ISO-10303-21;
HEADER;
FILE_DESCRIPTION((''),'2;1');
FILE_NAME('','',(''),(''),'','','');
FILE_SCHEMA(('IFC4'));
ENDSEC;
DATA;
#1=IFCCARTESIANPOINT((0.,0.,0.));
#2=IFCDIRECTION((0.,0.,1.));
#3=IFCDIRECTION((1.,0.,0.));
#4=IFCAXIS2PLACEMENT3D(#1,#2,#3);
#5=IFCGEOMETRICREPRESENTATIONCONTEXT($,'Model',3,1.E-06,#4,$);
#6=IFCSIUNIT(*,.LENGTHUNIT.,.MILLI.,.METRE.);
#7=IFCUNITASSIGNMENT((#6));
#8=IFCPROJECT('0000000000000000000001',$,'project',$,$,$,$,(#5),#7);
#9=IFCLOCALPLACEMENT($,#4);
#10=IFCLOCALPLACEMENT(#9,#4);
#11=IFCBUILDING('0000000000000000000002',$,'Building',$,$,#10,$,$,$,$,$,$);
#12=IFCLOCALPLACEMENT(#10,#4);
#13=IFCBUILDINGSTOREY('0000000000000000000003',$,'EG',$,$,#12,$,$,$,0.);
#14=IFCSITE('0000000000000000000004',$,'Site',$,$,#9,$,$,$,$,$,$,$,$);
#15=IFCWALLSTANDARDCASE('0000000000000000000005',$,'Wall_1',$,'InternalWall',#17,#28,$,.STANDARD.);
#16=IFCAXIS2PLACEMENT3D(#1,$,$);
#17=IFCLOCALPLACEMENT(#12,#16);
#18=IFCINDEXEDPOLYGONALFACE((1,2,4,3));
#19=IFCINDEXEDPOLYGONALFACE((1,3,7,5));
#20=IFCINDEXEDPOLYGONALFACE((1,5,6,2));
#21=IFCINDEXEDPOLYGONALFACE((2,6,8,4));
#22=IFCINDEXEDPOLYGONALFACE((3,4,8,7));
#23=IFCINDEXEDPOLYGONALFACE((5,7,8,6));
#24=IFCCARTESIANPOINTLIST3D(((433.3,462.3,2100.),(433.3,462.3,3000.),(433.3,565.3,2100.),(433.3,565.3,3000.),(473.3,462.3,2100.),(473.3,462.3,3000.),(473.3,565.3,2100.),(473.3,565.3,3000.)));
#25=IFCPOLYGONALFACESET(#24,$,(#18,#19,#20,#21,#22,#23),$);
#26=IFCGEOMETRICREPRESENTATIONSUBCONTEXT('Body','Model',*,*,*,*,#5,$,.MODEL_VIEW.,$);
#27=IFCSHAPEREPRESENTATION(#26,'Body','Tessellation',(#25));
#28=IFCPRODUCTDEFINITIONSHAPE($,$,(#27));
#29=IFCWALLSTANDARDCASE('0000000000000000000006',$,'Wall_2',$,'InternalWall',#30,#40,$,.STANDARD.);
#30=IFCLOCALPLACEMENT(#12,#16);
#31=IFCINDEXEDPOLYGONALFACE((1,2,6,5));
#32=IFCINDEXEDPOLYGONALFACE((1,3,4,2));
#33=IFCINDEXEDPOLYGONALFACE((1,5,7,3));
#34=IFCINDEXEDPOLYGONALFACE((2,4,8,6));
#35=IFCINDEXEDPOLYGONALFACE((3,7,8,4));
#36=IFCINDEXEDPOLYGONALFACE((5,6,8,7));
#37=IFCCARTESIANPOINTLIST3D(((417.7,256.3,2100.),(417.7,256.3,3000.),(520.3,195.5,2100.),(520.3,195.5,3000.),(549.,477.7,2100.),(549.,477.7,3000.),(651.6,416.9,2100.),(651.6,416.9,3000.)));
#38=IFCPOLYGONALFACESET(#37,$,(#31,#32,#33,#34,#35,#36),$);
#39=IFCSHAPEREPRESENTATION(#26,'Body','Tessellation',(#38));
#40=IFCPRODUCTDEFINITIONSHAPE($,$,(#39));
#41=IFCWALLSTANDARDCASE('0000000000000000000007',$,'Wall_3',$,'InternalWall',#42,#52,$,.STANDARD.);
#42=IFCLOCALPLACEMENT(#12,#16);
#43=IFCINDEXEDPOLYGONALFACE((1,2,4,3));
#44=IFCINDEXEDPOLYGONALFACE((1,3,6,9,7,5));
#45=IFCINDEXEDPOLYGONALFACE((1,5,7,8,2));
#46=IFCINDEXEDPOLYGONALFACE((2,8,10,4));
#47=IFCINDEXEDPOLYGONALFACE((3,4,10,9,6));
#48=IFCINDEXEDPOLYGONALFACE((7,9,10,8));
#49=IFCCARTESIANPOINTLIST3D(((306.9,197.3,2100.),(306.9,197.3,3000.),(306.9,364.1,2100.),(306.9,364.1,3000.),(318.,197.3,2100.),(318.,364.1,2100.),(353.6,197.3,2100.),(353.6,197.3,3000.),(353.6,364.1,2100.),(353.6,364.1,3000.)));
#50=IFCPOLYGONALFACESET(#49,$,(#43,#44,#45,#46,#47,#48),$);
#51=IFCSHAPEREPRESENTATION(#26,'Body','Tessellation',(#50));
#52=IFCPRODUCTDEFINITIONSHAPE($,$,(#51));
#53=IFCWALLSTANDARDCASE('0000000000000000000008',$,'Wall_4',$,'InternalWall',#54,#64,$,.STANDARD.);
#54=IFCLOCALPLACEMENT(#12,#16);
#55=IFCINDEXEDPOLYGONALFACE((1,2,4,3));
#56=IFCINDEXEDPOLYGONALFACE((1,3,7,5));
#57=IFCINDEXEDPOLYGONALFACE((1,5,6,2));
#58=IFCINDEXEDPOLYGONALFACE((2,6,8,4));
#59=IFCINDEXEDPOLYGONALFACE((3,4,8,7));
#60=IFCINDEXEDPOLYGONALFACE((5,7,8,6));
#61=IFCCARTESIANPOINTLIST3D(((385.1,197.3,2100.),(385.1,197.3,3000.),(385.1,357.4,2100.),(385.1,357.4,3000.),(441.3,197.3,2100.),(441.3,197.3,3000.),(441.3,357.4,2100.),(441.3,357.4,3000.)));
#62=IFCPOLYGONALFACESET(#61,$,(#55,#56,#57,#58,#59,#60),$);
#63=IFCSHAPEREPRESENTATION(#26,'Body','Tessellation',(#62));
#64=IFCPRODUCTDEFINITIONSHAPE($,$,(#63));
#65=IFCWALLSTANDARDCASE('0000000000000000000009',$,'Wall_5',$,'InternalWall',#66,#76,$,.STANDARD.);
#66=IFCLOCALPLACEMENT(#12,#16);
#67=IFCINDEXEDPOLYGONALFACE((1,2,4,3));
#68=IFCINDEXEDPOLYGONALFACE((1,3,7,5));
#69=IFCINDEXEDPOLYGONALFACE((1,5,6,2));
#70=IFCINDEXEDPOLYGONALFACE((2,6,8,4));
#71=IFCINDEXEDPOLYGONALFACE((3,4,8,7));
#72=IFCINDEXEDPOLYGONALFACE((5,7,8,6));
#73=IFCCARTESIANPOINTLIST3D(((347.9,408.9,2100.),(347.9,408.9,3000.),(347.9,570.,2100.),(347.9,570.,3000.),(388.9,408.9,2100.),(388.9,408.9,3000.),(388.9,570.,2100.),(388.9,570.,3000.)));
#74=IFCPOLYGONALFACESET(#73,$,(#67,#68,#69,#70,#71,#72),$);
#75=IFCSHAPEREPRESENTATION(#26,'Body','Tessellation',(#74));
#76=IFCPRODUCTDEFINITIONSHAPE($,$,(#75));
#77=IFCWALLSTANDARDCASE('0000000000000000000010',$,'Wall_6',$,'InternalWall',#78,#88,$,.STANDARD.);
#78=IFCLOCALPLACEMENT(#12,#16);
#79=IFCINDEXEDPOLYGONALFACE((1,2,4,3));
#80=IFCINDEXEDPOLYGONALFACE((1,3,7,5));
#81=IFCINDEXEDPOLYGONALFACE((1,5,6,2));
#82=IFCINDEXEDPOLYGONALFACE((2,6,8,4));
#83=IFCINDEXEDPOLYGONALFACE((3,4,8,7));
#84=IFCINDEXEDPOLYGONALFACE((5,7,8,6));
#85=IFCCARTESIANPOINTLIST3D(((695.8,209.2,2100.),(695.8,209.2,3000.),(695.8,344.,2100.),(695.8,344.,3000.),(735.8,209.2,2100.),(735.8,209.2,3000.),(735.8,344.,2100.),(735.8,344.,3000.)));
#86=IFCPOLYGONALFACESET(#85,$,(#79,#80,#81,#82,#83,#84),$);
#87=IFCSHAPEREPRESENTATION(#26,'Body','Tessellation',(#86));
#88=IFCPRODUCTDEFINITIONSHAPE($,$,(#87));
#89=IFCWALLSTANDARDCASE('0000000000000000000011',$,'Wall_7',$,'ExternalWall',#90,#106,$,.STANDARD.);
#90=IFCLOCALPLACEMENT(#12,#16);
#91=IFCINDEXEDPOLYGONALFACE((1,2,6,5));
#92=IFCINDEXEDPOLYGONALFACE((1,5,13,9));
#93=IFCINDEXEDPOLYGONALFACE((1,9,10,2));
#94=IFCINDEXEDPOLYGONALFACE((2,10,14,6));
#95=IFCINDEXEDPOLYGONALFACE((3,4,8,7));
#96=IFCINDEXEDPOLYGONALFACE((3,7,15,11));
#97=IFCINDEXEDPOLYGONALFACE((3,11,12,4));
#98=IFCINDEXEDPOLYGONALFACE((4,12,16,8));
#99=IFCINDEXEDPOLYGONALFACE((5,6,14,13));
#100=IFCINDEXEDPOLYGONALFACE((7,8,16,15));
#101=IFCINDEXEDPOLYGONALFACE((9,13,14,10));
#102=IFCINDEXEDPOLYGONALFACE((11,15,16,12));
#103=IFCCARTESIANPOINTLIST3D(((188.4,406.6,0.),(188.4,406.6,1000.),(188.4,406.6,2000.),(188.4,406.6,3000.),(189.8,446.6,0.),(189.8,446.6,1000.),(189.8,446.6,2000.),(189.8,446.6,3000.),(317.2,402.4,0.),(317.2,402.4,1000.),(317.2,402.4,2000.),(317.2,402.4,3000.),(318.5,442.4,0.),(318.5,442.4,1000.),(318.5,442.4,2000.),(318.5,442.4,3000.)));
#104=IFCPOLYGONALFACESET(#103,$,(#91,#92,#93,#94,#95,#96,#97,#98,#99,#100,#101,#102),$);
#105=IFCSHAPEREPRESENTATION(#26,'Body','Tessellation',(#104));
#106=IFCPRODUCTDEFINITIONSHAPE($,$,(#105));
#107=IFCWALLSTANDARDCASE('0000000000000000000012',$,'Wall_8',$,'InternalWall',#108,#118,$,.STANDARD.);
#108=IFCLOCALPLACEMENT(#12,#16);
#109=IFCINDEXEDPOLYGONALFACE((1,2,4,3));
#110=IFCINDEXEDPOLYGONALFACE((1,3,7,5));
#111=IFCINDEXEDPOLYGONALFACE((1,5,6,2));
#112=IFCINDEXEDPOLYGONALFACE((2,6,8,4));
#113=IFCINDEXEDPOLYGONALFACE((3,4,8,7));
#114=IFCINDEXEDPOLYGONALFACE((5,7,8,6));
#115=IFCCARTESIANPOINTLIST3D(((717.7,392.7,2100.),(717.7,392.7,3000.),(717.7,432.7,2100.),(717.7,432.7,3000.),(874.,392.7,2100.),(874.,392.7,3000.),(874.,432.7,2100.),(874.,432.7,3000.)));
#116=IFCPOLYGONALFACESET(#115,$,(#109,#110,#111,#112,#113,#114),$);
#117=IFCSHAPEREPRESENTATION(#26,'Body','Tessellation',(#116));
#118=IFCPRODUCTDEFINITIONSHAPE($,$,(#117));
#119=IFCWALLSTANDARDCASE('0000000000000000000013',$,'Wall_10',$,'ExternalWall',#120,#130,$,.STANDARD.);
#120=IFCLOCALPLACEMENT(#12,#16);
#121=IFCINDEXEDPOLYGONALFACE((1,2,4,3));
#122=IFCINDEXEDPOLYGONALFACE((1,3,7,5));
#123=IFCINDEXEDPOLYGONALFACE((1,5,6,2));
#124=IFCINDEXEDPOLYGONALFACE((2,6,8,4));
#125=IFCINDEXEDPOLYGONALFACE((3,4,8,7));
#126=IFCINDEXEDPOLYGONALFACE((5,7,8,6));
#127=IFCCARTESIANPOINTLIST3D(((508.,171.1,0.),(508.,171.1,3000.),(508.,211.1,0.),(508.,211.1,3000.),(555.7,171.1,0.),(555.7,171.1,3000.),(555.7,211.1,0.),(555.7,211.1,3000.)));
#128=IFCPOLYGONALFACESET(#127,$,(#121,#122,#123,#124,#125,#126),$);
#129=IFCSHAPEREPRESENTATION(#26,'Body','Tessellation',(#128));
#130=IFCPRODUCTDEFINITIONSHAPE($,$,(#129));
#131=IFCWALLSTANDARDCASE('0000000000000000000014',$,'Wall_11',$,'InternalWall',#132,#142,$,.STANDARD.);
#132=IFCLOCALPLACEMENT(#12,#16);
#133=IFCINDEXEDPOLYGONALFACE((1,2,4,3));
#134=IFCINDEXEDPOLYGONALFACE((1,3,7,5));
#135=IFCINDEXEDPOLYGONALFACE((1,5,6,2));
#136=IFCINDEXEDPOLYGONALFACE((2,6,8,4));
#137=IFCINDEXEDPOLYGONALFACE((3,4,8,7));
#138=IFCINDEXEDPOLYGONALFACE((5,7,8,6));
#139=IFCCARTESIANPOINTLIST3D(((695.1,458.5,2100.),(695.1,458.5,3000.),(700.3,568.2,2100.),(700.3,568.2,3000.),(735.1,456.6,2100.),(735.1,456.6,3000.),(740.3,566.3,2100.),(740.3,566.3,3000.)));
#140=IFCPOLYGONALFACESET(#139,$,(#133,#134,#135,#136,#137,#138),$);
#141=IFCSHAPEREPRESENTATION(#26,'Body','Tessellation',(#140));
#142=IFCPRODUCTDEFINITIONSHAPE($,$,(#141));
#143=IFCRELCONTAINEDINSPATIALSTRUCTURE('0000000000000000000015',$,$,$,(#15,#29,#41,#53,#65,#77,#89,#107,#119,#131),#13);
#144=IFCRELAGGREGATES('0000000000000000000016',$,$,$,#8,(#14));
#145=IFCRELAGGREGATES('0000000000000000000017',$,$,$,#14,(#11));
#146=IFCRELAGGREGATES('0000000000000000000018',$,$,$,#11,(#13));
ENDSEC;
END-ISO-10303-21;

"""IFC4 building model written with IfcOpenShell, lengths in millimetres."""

from ifc_helpers import new_model, si_unit, frame, origin_with_axes, place, context, subcontext, project, spatial, rectangle, extrude, element, save


model = new_model("IFC4")

# Units and contexts
model_context = context("Model", 3, precision=1e-06, world=origin_with_axes())
body_context = subcontext(model_context, "Body", "Model", "MODEL_VIEW")
ifc_project = project(units=[si_unit("LENGTHUNIT", "METRE", prefix="MILLI")], contexts=[model_context])

# Site, building, storey
site_placement = place(None, origin_with_axes())
site = spatial("IfcSite", under=ifc_project, at=site_placement, Name="Site")
building_placement = place(site_placement, origin_with_axes())
building = spatial("IfcBuilding", under=site, at=building_placement, Name="Building")
storey_placement = place(building_placement, origin_with_axes())
storey = spatial("IfcBuildingStorey", under=building, at=storey_placement, Name="EG", Elevation=0.0)

# Walls, openings
wall_1_placement = place(storey_placement, origin_with_axes())
wall_1 = element("IfcWallStandardCase", 1, at=wall_1_placement, inside=storey, Name="Wall_1", ObjectType="InternalWall", PredefinedType="STANDARD", context=body_context, shape_type="SweptSolid", body=[
    extrude(rectangle(XDim=103.0, YDim=40.0), frame((453.3, 513.8, 0.0), z_axis=(0.0, 0.0, 1.0), x_axis=(0.0, 1.0, 0.0)), (0.0, 0.0, 1.0), 3000.0),
])
opening_1_placement = place(wall_1_placement, origin_with_axes())
element("IfcOpeningElement", 2, at=opening_1_placement, inside=storey, cuts=wall_1, context=body_context, shape_type="SweptSolid", body=[
    extrude(rectangle(XDim=450.0, YDim=40.0), frame((453.3, 481.3, 0.0), z_axis=(0.0, 0.0, 1.0), x_axis=(0.0, 1.0, 0.0)), (0.0, 0.0, 1.0), 2100.0),
])
opening_2_placement = place(wall_1_placement, origin_with_axes())
element("IfcOpeningElement", 3, at=opening_2_placement, inside=storey, cuts=wall_1, context=body_context, shape_type="SweptSolid", body=[
    extrude(rectangle(XDim=900.0, YDim=40.0), frame((403.6, 423.9, 0.0), z_axis=(0.0, 0.0, 1.0), x_axis=(0.0, 1.0, 0.0)), (0.0, 0.0, 1.0), 2100.0),
])
wall_2_placement = place(storey_placement, origin_with_axes())
wall_2 = element("IfcWallStandardCase", 4, at=wall_2_placement, inside=storey, Name="Wall_2", ObjectType="InternalWall", PredefinedType="STANDARD", context=body_context, shape_type="SweptSolid", body=[
    extrude(rectangle(XDim=257.4, YDim=119.2), frame((534.7, 336.6, 0.0), z_axis=(0.0, 0.0, 1.0), x_axis=(-0.510011, -0.860168, 0.0)), (0.0, 0.0, 1.0), 3000.0),
])
opening_3_placement = place(wall_2_placement, origin_with_axes())
element("IfcOpeningElement", 5, at=opening_3_placement, inside=storey, cuts=wall_2, context=body_context, shape_type="SweptSolid", body=[
    extrude(rectangle(XDim=450.0, YDim=119.2), frame((549.1, 360.9, 0.0), z_axis=(0.0, 0.0, 1.0), x_axis=(-0.510011, -0.860168, 0.0)), (0.0, 0.0, 1.0), 2100.0),
])
opening_4_placement = place(wall_2_placement, origin_with_axes())
element("IfcOpeningElement", 6, at=opening_4_placement, inside=storey, cuts=wall_2, context=body_context, shape_type="SweptSolid", body=[
    extrude(rectangle(XDim=450.0, YDim=119.2), frame((568.7, 394.1, 0.0), z_axis=(0.0, 0.0, 1.0), x_axis=(-0.510011, -0.860168, 0.0)), (0.0, 0.0, 1.0), 2100.0),
])
wall_3_placement = place(storey_placement, origin_with_axes())
wall_3 = element("IfcWallStandardCase", 7, at=wall_3_placement, inside=storey, Name="Wall_3", ObjectType="InternalWall", PredefinedType="STANDARD", context=body_context, shape_type="SweptSolid", body=[
    extrude(rectangle(XDim=166.8, YDim=46.7), frame((330.3, 280.7, 0.0), z_axis=(0.0, 0.0, 1.0), x_axis=(0.0, 1.0, 0.0)), (0.0, 0.0, 1.0), 3000.0),
])
opening_5_placement = place(wall_3_placement, origin_with_axes())
element("IfcOpeningElement", 8, at=opening_5_placement, inside=storey, cuts=wall_3, context=body_context, shape_type="SweptSolid", body=[
    extrude(rectangle(XDim=450.0, YDim=46.7), frame((330.3, 337.4, 0.0), z_axis=(0.0, 0.0, 1.0), x_axis=(0.0, 1.0, 0.0)), (0.0, 0.0, 1.0), 2100.0),
])
opening_6_placement = place(wall_3_placement, origin_with_axes())
element("IfcOpeningElement", 9, at=opening_6_placement, inside=storey, cuts=wall_3, context=body_context, shape_type="SweptSolid", body=[
    extrude(rectangle(XDim=900.0, YDim=46.7), frame((294.6, 386.3, 0.0), z_axis=(0.0, 0.0, 1.0), x_axis=(0.0, 1.0, 0.0)), (0.0, 0.0, 1.0), 2100.0),
])

# Walls, openings
wall_4_placement = place(storey_placement, origin_with_axes())
wall_4 = element("IfcWallStandardCase", 10, at=wall_4_placement, inside=storey, Name="Wall_4", ObjectType="InternalWall", PredefinedType="STANDARD", context=body_context, shape_type="SweptSolid", body=[
    extrude(rectangle(XDim=160.1, YDim=56.2), frame((413.2, 277.4, 0.0), z_axis=(0.0, 0.0, 1.0), x_axis=(0.0, 1.0, 0.0)), (0.0, 0.0, 1.0), 3000.0),
])
opening_7_placement = place(wall_4_placement, origin_with_axes())
element("IfcOpeningElement", 11, at=opening_7_placement, inside=storey, cuts=wall_4, context=body_context, shape_type="SweptSolid", body=[
    extrude(rectangle(XDim=450.0, YDim=56.2), frame((413.2, 335.5, 0.0), z_axis=(0.0, 0.0, 1.0), x_axis=(0.0, 1.0, 0.0)), (0.0, 0.0, 1.0), 2100.0),
])
wall_5_placement = place(storey_placement, origin_with_axes())
wall_5 = element("IfcWallStandardCase", 12, at=wall_5_placement, inside=storey, Name="Wall_5", ObjectType="InternalWall", PredefinedType="STANDARD", context=body_context, shape_type="SweptSolid", body=[
    extrude(rectangle(XDim=161.1, YDim=41.0), frame((368.4, 489.4, 0.0), z_axis=(0.0, 0.0, 1.0), x_axis=(0.0, 1.0, 0.0)), (0.0, 0.0, 1.0), 3000.0),
])
opening_8_placement = place(wall_5_placement, origin_with_axes())
element("IfcOpeningElement", 13, at=opening_8_placement, inside=storey, cuts=wall_5, context=body_context, shape_type="SweptSolid", body=[
    extrude(rectangle(XDim=450.0, YDim=41.0), frame((368.4, 428.9, 0.0), z_axis=(0.0, 0.0, 1.0), x_axis=(0.0, 1.0, 0.0)), (0.0, 0.0, 1.0), 2100.0),
])
wall_6_placement = place(storey_placement, origin_with_axes())
wall_6 = element("IfcWallStandardCase", 14, at=wall_6_placement, inside=storey, Name="Wall_6", ObjectType="InternalWall", PredefinedType="STANDARD", context=body_context, shape_type="SweptSolid", body=[
    extrude(rectangle(XDim=134.8, YDim=40.0), frame((715.8, 276.6, 0.0), z_axis=(0.0, 0.0, 1.0), x_axis=(0.0, -1.0, 0.0)), (0.0, 0.0, 1.0), 3000.0),
])
opening_9_placement = place(wall_6_placement, origin_with_axes())
element("IfcOpeningElement", 15, at=opening_9_placement, inside=storey, cuts=wall_6, context=body_context, shape_type="SweptSolid", body=[
    extrude(rectangle(XDim=450.0, YDim=40.0), frame((715.8, 330.2, 0.0), z_axis=(0.0, 0.0, 1.0), x_axis=(0.0, -1.0, 0.0)), (0.0, 0.0, 1.0), 2100.0),
])

# Walls, openings
wall_7_placement = place(storey_placement, origin_with_axes())
wall_7 = element("IfcWallStandardCase", 16, at=wall_7_placement, inside=storey, Name="Wall_7", ObjectType="ExternalWall", PredefinedType="STANDARD", context=body_context, shape_type="SweptSolid", body=[
    extrude(rectangle(XDim=128.8, YDim=40.0), frame((253.5, 424.5, 0.0), z_axis=(0.0, 0.0, 1.0), x_axis=(0.999454, -0.03304, 0.0)), (0.0, 0.0, 1.0), 3000.0),
])
opening_10_placement = place(wall_7_placement, origin_with_axes())
element("IfcOpeningElement", 17, at=opening_10_placement, inside=storey, cuts=wall_7, context=body_context, shape_type="SweptSolid", body=[
    extrude(rectangle(XDim=600.0, YDim=40.0), frame((194.3, 426.5, 1000.0), z_axis=(0.0, 0.0, 1.0), x_axis=(0.999454, -0.03304, 0.0)), (0.0, 0.0, 1.0), 1000.0),
])
opening_11_placement = place(wall_7_placement, origin_with_axes())
element("IfcOpeningElement", 18, at=opening_11_placement, inside=storey, cuts=wall_7, context=body_context, shape_type="SweptSolid", body=[
    extrude(rectangle(XDim=600.0, YDim=40.0), frame((189.2, 426.6, 1000.0), z_axis=(0.0, 0.0, 1.0), x_axis=(0.999454, -0.03304, 0.0)), (0.0, 0.0, 1.0), 1000.0),
])
wall_8_placement = place(storey_placement, origin_with_axes())
wall_8 = element("IfcWallStandardCase", 19, at=wall_8_placement, inside=storey, Name="Wall_8", ObjectType="InternalWall", PredefinedType="STANDARD", context=body_context, shape_type="SweptSolid", body=[
    extrude(rectangle(XDim=156.3, YDim=40.0), frame((795.9, 412.7, 0.0), z_axis=(0.0, 0.0, 1.0), x_axis=(-1.0, 0.0, 0.0)), (0.0, 0.0, 1.0), 3000.0),
])
opening_12_placement = place(wall_8_placement, origin_with_axes())
element("IfcOpeningElement", 20, at=opening_12_placement, inside=storey, cuts=wall_8, context=body_context, shape_type="SweptSolid", body=[
    extrude(rectangle(XDim=450.0, YDim=40.0), frame((738.2, 412.7, 0.0), z_axis=(0.0, 0.0, 1.0), x_axis=(-1.0, 0.0, 0.0)), (0.0, 0.0, 1.0), 2100.0),
])
opening_13_placement = place(wall_8_placement, origin_with_axes())
element("IfcOpeningElement", 21, at=opening_13_placement, inside=storey, cuts=wall_8, context=body_context, shape_type="SweptSolid", body=[
    extrude(rectangle(XDim=450.0, YDim=40.0), frame((733.9, 412.7, 0.0), z_axis=(0.0, 0.0, 1.0), x_axis=(-1.0, 0.0, 0.0)), (0.0, 0.0, 1.0), 2100.0),
])

# Wall
wall_9_placement = place(storey_placement, origin_with_axes())
element("IfcWallStandardCase", 22, at=wall_9_placement, inside=storey, Name="Wall_10", ObjectType="ExternalWall", PredefinedType="STANDARD", context=body_context, shape_type="SweptSolid", body=[
    extrude(rectangle(XDim=47.7, YDim=40.0), frame((531.8, 191.1, 0.0), z_axis=(0.0, 0.0, 1.0), x_axis=(-1.0, 0.0, 0.0)), (0.0, 0.0, 1.0), 3000.0),
])

# Wall, opening
wall_10_placement = place(storey_placement, origin_with_axes())
wall_10 = element("IfcWallStandardCase", 23, at=wall_10_placement, inside=storey, Name="Wall_11", ObjectType="InternalWall", PredefinedType="STANDARD", context=body_context, shape_type="SweptSolid", body=[
    extrude(rectangle(XDim=109.8, YDim=40.0), frame((717.7, 512.4, 0.0), z_axis=(0.0, 0.0, 1.0), x_axis=(-0.047565, -0.998868, 0.0)), (0.0, 0.0, 1.0), 3000.0),
])
opening_14_placement = place(wall_10_placement, origin_with_axes())
element("IfcOpeningElement", 24, at=opening_14_placement, inside=storey, cuts=wall_10, context=body_context, shape_type="SweptSolid", body=[
    extrude(rectangle(XDim=450.0, YDim=40.0), frame((716.1, 478.6, 0.0), z_axis=(0.0, 0.0, 1.0), x_axis=(-0.047565, -0.998868, 0.0)), (0.0, 0.0, 1.0), 2100.0),
])

save(model, "model.ifc")
